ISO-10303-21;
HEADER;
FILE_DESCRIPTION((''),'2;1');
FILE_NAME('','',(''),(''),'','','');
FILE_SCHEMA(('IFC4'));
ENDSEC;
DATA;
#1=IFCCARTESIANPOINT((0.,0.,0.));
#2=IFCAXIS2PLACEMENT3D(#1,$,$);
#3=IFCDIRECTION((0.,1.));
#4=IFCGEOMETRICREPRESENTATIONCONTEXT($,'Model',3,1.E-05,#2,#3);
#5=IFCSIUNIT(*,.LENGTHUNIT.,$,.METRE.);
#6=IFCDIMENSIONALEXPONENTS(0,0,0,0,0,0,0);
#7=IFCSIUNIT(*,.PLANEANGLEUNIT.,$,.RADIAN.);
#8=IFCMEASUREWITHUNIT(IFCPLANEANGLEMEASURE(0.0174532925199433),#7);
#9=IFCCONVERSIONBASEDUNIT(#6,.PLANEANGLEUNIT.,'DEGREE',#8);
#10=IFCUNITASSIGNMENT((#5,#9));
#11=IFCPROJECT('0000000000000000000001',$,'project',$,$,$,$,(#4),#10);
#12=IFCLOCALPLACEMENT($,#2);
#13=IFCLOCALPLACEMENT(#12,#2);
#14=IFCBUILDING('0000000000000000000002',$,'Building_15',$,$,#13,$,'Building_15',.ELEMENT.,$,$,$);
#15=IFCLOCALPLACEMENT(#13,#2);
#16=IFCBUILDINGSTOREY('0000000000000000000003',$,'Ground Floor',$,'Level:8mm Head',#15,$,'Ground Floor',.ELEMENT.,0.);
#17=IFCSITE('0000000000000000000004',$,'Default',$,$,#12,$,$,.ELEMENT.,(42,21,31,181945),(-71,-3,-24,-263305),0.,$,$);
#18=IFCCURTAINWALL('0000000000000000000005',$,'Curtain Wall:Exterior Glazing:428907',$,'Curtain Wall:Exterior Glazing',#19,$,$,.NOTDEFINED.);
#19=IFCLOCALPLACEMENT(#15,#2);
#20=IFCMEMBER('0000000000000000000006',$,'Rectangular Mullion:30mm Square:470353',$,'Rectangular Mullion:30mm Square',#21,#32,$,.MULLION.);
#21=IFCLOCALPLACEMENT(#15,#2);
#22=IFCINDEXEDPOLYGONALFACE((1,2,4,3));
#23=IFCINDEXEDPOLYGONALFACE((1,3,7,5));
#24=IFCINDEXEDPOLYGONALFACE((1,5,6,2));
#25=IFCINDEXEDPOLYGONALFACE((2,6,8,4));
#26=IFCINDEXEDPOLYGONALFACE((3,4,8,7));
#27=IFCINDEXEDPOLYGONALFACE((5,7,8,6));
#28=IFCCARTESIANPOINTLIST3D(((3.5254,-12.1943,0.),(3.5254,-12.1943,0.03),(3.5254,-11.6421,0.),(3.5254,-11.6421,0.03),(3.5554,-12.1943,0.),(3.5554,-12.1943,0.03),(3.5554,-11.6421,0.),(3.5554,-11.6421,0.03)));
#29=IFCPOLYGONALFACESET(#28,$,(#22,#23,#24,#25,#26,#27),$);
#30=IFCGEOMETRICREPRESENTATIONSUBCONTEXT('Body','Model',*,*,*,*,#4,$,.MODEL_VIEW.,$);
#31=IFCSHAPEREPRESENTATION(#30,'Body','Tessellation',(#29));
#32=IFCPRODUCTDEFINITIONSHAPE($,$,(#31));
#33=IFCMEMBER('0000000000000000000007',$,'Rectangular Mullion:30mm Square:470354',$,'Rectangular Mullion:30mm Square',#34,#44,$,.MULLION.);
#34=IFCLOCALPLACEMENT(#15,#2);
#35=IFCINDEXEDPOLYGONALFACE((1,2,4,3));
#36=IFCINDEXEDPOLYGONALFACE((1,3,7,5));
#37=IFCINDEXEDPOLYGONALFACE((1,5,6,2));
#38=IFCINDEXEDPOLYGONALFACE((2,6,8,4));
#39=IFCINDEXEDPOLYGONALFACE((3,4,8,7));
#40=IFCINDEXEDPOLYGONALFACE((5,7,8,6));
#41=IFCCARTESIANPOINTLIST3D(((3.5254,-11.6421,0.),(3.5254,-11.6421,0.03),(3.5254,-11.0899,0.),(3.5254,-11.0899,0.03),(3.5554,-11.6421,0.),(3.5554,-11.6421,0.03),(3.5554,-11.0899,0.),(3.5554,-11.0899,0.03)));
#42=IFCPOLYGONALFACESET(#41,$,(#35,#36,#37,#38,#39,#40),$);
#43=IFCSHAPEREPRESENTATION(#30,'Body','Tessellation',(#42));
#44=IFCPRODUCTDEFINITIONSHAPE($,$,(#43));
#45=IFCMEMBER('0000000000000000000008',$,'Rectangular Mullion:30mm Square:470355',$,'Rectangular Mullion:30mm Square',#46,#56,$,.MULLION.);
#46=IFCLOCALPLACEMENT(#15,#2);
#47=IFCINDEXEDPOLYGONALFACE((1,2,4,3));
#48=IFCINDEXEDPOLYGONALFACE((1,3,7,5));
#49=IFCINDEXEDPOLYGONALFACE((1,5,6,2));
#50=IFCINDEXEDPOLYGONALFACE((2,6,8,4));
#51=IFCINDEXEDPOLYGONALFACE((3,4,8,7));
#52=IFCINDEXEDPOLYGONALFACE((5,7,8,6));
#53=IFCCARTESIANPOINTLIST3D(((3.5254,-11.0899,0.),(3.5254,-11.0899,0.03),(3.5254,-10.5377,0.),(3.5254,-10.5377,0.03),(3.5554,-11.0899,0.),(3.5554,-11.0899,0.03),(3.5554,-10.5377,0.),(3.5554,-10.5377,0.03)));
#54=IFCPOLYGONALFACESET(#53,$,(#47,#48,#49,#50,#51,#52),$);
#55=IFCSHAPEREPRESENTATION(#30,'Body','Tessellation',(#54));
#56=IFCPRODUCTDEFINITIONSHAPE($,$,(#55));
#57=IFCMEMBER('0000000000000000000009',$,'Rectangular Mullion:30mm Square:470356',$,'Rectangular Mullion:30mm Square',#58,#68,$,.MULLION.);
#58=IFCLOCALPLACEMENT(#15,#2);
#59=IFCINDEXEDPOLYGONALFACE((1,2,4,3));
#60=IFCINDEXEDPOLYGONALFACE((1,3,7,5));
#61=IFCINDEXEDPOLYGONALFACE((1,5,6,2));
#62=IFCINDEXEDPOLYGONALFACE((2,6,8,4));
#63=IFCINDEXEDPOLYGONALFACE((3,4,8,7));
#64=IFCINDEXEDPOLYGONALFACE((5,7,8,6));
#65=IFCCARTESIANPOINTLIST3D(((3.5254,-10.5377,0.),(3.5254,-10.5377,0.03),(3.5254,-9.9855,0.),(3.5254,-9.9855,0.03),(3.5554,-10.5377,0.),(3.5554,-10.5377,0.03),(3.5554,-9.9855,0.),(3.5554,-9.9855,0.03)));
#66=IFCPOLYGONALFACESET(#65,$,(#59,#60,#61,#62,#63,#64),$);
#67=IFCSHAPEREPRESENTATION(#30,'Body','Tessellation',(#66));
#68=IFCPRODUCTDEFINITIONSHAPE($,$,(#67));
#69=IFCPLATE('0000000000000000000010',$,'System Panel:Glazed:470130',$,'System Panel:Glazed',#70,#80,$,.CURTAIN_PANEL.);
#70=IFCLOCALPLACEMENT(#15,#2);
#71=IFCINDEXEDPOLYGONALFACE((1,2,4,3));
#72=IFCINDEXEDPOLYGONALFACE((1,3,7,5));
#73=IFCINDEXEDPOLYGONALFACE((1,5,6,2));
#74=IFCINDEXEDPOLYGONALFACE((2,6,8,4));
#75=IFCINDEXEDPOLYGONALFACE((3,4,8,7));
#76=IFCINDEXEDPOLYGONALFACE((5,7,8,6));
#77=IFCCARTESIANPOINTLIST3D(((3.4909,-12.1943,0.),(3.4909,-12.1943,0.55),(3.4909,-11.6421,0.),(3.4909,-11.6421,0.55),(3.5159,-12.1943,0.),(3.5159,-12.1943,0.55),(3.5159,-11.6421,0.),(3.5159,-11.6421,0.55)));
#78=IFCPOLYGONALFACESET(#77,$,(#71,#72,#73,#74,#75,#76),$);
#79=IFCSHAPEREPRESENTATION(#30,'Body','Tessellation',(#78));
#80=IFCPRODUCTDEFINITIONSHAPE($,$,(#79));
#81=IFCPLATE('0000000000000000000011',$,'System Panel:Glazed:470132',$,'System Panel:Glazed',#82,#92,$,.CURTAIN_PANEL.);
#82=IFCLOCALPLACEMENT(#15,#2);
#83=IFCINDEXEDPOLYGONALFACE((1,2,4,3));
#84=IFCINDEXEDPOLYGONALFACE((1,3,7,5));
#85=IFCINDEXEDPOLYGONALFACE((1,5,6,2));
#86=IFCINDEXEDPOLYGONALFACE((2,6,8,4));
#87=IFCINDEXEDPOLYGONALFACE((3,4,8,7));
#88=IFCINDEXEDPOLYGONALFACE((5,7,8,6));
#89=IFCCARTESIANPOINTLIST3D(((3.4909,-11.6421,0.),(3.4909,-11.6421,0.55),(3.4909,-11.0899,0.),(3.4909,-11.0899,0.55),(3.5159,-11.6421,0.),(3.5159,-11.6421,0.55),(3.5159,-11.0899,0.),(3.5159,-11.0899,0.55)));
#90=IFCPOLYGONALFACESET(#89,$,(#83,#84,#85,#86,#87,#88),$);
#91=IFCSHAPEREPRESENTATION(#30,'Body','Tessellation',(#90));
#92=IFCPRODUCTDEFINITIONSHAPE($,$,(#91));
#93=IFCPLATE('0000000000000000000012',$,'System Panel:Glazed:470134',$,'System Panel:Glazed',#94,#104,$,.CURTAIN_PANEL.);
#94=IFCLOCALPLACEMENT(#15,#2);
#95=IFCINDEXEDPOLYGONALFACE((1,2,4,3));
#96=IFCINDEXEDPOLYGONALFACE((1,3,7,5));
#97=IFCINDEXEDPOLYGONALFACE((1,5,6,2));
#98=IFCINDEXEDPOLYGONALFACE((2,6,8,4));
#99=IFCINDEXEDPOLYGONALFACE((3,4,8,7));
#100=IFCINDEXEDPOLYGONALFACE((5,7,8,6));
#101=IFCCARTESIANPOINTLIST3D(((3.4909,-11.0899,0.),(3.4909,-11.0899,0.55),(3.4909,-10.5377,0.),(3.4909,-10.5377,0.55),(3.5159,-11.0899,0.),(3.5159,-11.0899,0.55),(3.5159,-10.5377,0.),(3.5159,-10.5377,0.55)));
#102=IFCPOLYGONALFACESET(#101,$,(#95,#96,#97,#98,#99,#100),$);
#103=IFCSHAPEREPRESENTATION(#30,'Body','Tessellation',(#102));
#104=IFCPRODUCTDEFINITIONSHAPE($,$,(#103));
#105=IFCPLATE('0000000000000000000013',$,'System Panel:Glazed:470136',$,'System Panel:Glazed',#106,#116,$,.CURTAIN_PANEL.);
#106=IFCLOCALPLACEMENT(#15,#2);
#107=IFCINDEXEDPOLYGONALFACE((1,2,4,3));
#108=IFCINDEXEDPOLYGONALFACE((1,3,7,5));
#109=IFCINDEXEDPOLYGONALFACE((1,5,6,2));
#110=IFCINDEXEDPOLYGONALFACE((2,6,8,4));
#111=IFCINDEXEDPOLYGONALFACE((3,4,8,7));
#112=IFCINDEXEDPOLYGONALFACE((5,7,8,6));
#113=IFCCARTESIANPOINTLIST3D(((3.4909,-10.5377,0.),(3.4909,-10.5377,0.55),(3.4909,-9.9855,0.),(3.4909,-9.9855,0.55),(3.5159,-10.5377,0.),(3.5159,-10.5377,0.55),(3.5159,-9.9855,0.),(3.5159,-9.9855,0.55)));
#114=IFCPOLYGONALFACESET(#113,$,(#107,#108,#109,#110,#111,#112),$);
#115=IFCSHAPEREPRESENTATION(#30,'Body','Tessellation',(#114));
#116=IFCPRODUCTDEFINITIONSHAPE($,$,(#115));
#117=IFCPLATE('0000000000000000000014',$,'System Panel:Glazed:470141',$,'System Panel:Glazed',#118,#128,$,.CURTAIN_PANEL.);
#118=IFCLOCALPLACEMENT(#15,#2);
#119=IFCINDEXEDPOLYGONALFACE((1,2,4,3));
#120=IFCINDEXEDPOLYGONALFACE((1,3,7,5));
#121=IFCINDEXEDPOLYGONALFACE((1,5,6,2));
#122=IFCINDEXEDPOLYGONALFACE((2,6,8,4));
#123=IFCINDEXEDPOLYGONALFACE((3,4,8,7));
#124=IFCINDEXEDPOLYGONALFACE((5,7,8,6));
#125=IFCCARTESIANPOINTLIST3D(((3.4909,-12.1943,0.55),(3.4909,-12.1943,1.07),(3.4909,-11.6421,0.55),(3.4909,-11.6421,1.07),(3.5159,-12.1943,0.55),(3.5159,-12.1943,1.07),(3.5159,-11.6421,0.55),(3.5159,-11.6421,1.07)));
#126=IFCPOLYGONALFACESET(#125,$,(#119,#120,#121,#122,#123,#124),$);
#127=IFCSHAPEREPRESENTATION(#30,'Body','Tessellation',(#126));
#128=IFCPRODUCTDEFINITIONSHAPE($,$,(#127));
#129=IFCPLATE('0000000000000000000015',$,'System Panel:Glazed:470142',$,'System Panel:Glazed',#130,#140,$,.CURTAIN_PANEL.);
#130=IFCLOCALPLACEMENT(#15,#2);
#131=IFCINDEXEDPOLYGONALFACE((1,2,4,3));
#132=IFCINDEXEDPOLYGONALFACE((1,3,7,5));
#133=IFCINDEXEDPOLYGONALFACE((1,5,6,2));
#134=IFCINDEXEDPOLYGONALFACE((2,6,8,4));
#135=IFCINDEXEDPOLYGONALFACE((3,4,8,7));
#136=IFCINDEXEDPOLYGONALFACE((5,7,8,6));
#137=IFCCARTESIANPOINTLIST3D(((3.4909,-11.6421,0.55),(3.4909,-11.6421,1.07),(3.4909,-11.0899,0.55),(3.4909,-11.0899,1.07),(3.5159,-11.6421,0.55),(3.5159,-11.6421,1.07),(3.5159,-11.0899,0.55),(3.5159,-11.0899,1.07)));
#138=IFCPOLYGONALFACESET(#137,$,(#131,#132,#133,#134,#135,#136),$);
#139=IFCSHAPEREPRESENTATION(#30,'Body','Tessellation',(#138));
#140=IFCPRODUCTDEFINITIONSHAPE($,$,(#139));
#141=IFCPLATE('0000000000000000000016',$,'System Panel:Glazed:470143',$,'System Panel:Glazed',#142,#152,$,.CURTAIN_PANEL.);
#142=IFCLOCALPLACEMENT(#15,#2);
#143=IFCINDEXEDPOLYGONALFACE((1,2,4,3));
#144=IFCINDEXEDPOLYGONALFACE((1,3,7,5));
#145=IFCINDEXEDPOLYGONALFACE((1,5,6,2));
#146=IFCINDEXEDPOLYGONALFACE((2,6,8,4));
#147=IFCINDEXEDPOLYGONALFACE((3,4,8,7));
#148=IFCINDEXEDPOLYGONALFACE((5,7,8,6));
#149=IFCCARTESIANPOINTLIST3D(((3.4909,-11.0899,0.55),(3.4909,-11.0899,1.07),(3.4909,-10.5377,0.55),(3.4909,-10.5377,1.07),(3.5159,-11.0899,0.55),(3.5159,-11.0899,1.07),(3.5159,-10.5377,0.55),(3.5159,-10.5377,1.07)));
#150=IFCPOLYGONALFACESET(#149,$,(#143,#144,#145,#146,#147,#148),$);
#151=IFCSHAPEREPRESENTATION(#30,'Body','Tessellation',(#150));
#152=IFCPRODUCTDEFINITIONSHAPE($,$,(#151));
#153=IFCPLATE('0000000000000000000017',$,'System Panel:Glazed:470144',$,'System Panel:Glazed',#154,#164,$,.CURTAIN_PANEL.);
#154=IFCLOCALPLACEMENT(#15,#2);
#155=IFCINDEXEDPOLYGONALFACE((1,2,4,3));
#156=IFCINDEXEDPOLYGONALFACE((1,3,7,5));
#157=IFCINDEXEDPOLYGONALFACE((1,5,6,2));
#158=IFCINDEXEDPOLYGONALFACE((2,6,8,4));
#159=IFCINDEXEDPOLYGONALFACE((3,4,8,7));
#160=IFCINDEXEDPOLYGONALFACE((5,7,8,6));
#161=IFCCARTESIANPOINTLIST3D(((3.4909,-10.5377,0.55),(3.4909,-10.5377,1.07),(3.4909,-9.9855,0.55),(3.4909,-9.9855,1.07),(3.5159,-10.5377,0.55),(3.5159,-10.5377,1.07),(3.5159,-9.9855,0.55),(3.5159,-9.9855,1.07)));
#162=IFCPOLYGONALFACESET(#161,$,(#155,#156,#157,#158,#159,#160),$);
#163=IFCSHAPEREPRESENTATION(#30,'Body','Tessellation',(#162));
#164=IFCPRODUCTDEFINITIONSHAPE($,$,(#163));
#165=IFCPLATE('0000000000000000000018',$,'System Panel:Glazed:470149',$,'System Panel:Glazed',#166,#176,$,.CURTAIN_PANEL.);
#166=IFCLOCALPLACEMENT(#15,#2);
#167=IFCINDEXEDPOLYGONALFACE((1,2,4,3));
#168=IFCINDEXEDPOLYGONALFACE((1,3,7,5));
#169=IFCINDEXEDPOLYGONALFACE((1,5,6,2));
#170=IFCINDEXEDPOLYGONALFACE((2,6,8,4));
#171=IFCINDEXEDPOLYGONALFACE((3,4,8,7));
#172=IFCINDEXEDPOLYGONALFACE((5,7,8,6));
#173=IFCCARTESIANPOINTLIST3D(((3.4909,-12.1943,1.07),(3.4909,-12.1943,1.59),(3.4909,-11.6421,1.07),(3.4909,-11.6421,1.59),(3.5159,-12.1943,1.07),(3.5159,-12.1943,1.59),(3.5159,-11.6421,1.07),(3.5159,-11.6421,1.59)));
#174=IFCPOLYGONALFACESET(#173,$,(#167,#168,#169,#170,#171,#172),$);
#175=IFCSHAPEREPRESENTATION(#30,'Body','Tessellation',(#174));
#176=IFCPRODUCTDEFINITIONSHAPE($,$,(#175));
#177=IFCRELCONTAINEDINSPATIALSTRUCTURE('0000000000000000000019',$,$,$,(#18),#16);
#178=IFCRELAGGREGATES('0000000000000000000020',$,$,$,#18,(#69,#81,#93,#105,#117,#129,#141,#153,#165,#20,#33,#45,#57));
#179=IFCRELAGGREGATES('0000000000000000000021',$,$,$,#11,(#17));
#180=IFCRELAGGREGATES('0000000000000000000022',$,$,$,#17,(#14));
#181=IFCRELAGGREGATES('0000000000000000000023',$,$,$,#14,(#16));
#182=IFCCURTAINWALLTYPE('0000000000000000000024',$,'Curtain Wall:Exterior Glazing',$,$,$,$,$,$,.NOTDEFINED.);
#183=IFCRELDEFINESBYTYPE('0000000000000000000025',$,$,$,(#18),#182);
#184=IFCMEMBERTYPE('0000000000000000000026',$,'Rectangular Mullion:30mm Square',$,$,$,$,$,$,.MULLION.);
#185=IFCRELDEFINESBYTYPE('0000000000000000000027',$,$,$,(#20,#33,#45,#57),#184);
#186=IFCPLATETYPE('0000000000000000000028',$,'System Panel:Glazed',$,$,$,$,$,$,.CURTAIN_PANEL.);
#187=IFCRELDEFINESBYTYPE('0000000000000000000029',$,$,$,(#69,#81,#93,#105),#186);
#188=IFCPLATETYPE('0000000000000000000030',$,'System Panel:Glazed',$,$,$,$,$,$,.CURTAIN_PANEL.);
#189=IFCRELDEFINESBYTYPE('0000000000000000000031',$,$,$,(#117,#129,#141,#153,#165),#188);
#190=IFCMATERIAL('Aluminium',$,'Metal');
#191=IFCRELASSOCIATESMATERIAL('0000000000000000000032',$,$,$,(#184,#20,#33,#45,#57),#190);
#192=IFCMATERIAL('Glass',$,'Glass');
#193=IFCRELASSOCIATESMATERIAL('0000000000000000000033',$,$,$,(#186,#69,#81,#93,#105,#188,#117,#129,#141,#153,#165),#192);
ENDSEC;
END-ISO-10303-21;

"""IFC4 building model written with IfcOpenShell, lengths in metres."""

from ifc_helpers import new_model, entity, si_unit, converted_unit, direction, frame, origin, place, context, subcontext, project, spatial, indexed_curve, outline, extrude, source, transform, mapped, material, type_object, type_shapes, element, aggregate, save


model = new_model("IFC4")

# Units and contexts
model_context = context("Model", 3, precision=1e-05, world=origin(), true_north=direction((0.0, 1.0)))
body_context = subcontext(model_context, "Body", "Model", "MODEL_VIEW")
ifc_project = project(units=[si_unit("LENGTHUNIT", "METRE"), converted_unit("PLANEANGLEUNIT", "DEGREE", entity("IfcPlaneAngleMeasure", 0.0174532925199433), si_unit("PLANEANGLEUNIT", "RADIAN"), dimensions=[0, 0, 0, 0, 0, 0, 0])], contexts=[model_context])

# Site, building, storey
site_placement = place(None, origin())
site = spatial("IfcSite", under=ifc_project, at=site_placement, Name="Default", CompositionType="ELEMENT", RefLatitude=(42, 21, 31, 181945), RefLongitude=(-71, -3, -24, -263305), RefElevation=0.0)
building_placement = place(site_placement, origin())
building = spatial("IfcBuilding", under=site, at=building_placement, Name="Building_15", LongName="Building_15", CompositionType="ELEMENT")
storey_placement = place(building_placement, origin())
storey = spatial("IfcBuildingStorey", under=building, at=storey_placement, Name="Ground Floor", ObjectType="Level:8mm Head", LongName="Ground Floor", CompositionType="ELEMENT", Elevation=0.0)

# Curtain wall, members, plates
curtain_wall_type = type_object("IfcCurtainWallType", Name="Curtain Wall:Exterior Glazing", PredefinedType="NOTDEFINED")
curtain_wall_placement = place(storey_placement, origin())
curtain_wall = element("IfcCurtainWall", 1, at=curtain_wall_placement, inside=storey, type_object=curtain_wall_type, Name="Curtain Wall:Exterior Glazing:428907", ObjectType="Curtain Wall:Exterior Glazing", PredefinedType="NOTDEFINED")
ifc_material_1 = material(Name="Aluminium", Category="Metal")
member_type = type_object("IfcMemberType", Name="Rectangular Mullion:30mm Square", PredefinedType="MULLION", material=ifc_material_1)
shared_shape_1 = source(origin(), body_context, "Body", "SweptSolid", [
    extrude(outline(indexed_curve([(-0.015, -0.015), (0.015, -0.015), (0.015, 0.015), (-0.015, 0.015), (-0.015, -0.015)], self_intersect=False)), frame((-0.015, 0.0, -0.5522), z_axis=(0.0, 0.0, 1.0), x_axis=(-1.0, 0.0, 0.0)), (0.0, 0.0, 1.0), 0.5522),
])
type_shapes(member_type, [shared_shape_1])
member_1_placement = place(curtain_wall_placement, frame((3.5404, -12.1943, 0.0), z_axis=(0.0, -1.0, 0.0), x_axis=(0.0, 0.0, -1.0)))
member_1 = element("IfcMember", 2, at=member_1_placement, type_object=member_type, material=ifc_material_1, Name="Rectangular Mullion:30mm Square:470353", ObjectType="Rectangular Mullion:30mm Square", PredefinedType="MULLION", context=body_context, shape_type="MappedRepresentation", body=[
    mapped(shared_shape_1, transform((0.0, 0.0, 0.0), scale=1.0)),
])
member_2_placement = place(curtain_wall_placement, frame((3.5404, -11.6421, 0.0), z_axis=(0.0, -1.0, 0.0), x_axis=(0.0, 0.0, -1.0)))
member_2 = element("IfcMember", 3, at=member_2_placement, type_object=member_type, material=ifc_material_1, Name="Rectangular Mullion:30mm Square:470354", ObjectType="Rectangular Mullion:30mm Square", PredefinedType="MULLION", context=body_context, shape_type="MappedRepresentation", body=[
    mapped(shared_shape_1, transform((0.0, 0.0, 0.0), scale=1.0)),
])
member_3_placement = place(curtain_wall_placement, frame((3.5404, -11.0899, 0.0), z_axis=(0.0, -1.0, 0.0), x_axis=(0.0, 0.0, -1.0)))
member_3 = element("IfcMember", 4, at=member_3_placement, type_object=member_type, material=ifc_material_1, Name="Rectangular Mullion:30mm Square:470355", ObjectType="Rectangular Mullion:30mm Square", PredefinedType="MULLION", context=body_context, shape_type="MappedRepresentation", body=[
    mapped(shared_shape_1, transform((0.0, 0.0, 0.0), scale=1.0)),
])
member_4_placement = place(curtain_wall_placement, frame((3.5404, -10.5377, 0.0), z_axis=(0.0, -1.0, 0.0), x_axis=(0.0, 0.0, -1.0)))
member_4 = element("IfcMember", 5, at=member_4_placement, type_object=member_type, material=ifc_material_1, Name="Rectangular Mullion:30mm Square:470356", ObjectType="Rectangular Mullion:30mm Square", PredefinedType="MULLION", context=body_context, shape_type="MappedRepresentation", body=[
    mapped(shared_shape_1, transform((0.0, 0.0, 0.0), scale=1.0)),
])
ifc_material_2 = material(Name="Glass", Category="Glass")
plate_type_1 = type_object("IfcPlateType", Name="System Panel:Glazed", PredefinedType="CURTAIN_PANEL", material=ifc_material_2)
shared_shape_2 = source(origin(), body_context, "Body", "SweptSolid", [
    extrude(outline(indexed_curve([(-0.0125, -0.2761), (0.0125, -0.2761), (0.0125, 0.2761), (-0.0125, 0.2761), (-0.0125, -0.2761)], self_intersect=False)), frame((0.0, 0.037, 0.0), z_axis=(0.0, 0.0, 1.0), x_axis=(0.0, 1.0, 0.0)), (0.0, 0.0, 1.0), 0.55),
])
type_shapes(plate_type_1, [shared_shape_2])
plate_1_placement = place(curtain_wall_placement, frame((3.5404, -11.9182, 0.0), z_axis=(0.0, 0.0, 1.0), x_axis=(0.0, 1.0, 0.0)))
plate_1 = element("IfcPlate", 6, at=plate_1_placement, type_object=plate_type_1, material=ifc_material_2, Name="System Panel:Glazed:470130", ObjectType="System Panel:Glazed", PredefinedType="CURTAIN_PANEL", context=body_context, shape_type="MappedRepresentation", body=[
    mapped(shared_shape_2, transform((0.0, 0.0, 0.0), scale=1.0)),
])
plate_2_placement = place(curtain_wall_placement, frame((3.5404, -11.366, 0.0), z_axis=(0.0, 0.0, 1.0), x_axis=(0.0, 1.0, 0.0)))
plate_2 = element("IfcPlate", 7, at=plate_2_placement, type_object=plate_type_1, material=ifc_material_2, Name="System Panel:Glazed:470132", ObjectType="System Panel:Glazed", PredefinedType="CURTAIN_PANEL", context=body_context, shape_type="MappedRepresentation", body=[
    mapped(shared_shape_2, transform((0.0, 0.0, 0.0), scale=1.0)),
])
plate_3_placement = place(curtain_wall_placement, frame((3.5404, -10.8138, 0.0), z_axis=(0.0, 0.0, 1.0), x_axis=(0.0, 1.0, 0.0)))
plate_3 = element("IfcPlate", 8, at=plate_3_placement, type_object=plate_type_1, material=ifc_material_2, Name="System Panel:Glazed:470134", ObjectType="System Panel:Glazed", PredefinedType="CURTAIN_PANEL", context=body_context, shape_type="MappedRepresentation", body=[
    mapped(shared_shape_2, transform((0.0, 0.0, 0.0), scale=1.0)),
])
plate_4_placement = place(curtain_wall_placement, frame((3.5404, -10.2616, 0.0), z_axis=(0.0, 0.0, 1.0), x_axis=(0.0, 1.0, 0.0)))
plate_4 = element("IfcPlate", 9, at=plate_4_placement, type_object=plate_type_1, material=ifc_material_2, Name="System Panel:Glazed:470136", ObjectType="System Panel:Glazed", PredefinedType="CURTAIN_PANEL", context=body_context, shape_type="MappedRepresentation", body=[
    mapped(shared_shape_2, transform((0.0, 0.0, 0.0), scale=1.0)),
])
plate_type_2 = type_object("IfcPlateType", Name="System Panel:Glazed", PredefinedType="CURTAIN_PANEL", material=ifc_material_2)
shared_shape_3 = source(origin(), body_context, "Body", "SweptSolid", [
    extrude(outline(indexed_curve([(-0.0125, -0.2761), (0.0125, -0.2761), (0.0125, 0.2761), (-0.0125, 0.2761), (-0.0125, -0.2761)], self_intersect=False)), frame((0.0, 0.037, 0.0), z_axis=(0.0, 0.0, 1.0), x_axis=(0.0, 1.0, 0.0)), (0.0, 0.0, 1.0), 0.52),
])
type_shapes(plate_type_2, [shared_shape_3])
plate_5_placement = place(curtain_wall_placement, frame((3.5404, -11.9182, 0.55), z_axis=(0.0, 0.0, 1.0), x_axis=(0.0, 1.0, 0.0)))
plate_5 = element("IfcPlate", 10, at=plate_5_placement, type_object=plate_type_2, material=ifc_material_2, Name="System Panel:Glazed:470141", ObjectType="System Panel:Glazed", PredefinedType="CURTAIN_PANEL", context=body_context, shape_type="MappedRepresentation", body=[
    mapped(shared_shape_3, transform((0.0, 0.0, 0.0), scale=1.0)),
])
plate_6_placement = place(curtain_wall_placement, frame((3.5404, -11.366, 0.55), z_axis=(0.0, 0.0, 1.0), x_axis=(0.0, 1.0, 0.0)))
plate_6 = element("IfcPlate", 11, at=plate_6_placement, type_object=plate_type_2, material=ifc_material_2, Name="System Panel:Glazed:470142", ObjectType="System Panel:Glazed", PredefinedType="CURTAIN_PANEL", context=body_context, shape_type="MappedRepresentation", body=[
    mapped(shared_shape_3, transform((0.0, 0.0, 0.0), scale=1.0)),
])
plate_7_placement = place(curtain_wall_placement, frame((3.5404, -10.8138, 0.55), z_axis=(0.0, 0.0, 1.0), x_axis=(0.0, 1.0, 0.0)))
plate_7 = element("IfcPlate", 12, at=plate_7_placement, type_object=plate_type_2, material=ifc_material_2, Name="System Panel:Glazed:470143", ObjectType="System Panel:Glazed", PredefinedType="CURTAIN_PANEL", context=body_context, shape_type="MappedRepresentation", body=[
    mapped(shared_shape_3, transform((0.0, 0.0, 0.0), scale=1.0)),
])
plate_8_placement = place(curtain_wall_placement, frame((3.5404, -10.2616, 0.55), z_axis=(0.0, 0.0, 1.0), x_axis=(0.0, 1.0, 0.0)))
plate_8 = element("IfcPlate", 13, at=plate_8_placement, type_object=plate_type_2, material=ifc_material_2, Name="System Panel:Glazed:470144", ObjectType="System Panel:Glazed", PredefinedType="CURTAIN_PANEL", context=body_context, shape_type="MappedRepresentation", body=[
    mapped(shared_shape_3, transform((0.0, 0.0, 0.0), scale=1.0)),
])
plate_9_placement = place(curtain_wall_placement, frame((3.5404, -11.9182, 1.07), z_axis=(0.0, 0.0, 1.0), x_axis=(0.0, 1.0, 0.0)))
plate_9 = element("IfcPlate", 14, at=plate_9_placement, type_object=plate_type_2, material=ifc_material_2, Name="System Panel:Glazed:470149", ObjectType="System Panel:Glazed", PredefinedType="CURTAIN_PANEL", context=body_context, shape_type="MappedRepresentation", body=[
    mapped(shared_shape_3, transform((0.0, 0.0, 0.0), scale=1.0)),
])
aggregate(curtain_wall, [plate_1, plate_2, plate_3, plate_4, plate_5, plate_6, plate_7, plate_8, plate_9, member_1, member_2, member_3, member_4])

save(model, "model.ifc")
